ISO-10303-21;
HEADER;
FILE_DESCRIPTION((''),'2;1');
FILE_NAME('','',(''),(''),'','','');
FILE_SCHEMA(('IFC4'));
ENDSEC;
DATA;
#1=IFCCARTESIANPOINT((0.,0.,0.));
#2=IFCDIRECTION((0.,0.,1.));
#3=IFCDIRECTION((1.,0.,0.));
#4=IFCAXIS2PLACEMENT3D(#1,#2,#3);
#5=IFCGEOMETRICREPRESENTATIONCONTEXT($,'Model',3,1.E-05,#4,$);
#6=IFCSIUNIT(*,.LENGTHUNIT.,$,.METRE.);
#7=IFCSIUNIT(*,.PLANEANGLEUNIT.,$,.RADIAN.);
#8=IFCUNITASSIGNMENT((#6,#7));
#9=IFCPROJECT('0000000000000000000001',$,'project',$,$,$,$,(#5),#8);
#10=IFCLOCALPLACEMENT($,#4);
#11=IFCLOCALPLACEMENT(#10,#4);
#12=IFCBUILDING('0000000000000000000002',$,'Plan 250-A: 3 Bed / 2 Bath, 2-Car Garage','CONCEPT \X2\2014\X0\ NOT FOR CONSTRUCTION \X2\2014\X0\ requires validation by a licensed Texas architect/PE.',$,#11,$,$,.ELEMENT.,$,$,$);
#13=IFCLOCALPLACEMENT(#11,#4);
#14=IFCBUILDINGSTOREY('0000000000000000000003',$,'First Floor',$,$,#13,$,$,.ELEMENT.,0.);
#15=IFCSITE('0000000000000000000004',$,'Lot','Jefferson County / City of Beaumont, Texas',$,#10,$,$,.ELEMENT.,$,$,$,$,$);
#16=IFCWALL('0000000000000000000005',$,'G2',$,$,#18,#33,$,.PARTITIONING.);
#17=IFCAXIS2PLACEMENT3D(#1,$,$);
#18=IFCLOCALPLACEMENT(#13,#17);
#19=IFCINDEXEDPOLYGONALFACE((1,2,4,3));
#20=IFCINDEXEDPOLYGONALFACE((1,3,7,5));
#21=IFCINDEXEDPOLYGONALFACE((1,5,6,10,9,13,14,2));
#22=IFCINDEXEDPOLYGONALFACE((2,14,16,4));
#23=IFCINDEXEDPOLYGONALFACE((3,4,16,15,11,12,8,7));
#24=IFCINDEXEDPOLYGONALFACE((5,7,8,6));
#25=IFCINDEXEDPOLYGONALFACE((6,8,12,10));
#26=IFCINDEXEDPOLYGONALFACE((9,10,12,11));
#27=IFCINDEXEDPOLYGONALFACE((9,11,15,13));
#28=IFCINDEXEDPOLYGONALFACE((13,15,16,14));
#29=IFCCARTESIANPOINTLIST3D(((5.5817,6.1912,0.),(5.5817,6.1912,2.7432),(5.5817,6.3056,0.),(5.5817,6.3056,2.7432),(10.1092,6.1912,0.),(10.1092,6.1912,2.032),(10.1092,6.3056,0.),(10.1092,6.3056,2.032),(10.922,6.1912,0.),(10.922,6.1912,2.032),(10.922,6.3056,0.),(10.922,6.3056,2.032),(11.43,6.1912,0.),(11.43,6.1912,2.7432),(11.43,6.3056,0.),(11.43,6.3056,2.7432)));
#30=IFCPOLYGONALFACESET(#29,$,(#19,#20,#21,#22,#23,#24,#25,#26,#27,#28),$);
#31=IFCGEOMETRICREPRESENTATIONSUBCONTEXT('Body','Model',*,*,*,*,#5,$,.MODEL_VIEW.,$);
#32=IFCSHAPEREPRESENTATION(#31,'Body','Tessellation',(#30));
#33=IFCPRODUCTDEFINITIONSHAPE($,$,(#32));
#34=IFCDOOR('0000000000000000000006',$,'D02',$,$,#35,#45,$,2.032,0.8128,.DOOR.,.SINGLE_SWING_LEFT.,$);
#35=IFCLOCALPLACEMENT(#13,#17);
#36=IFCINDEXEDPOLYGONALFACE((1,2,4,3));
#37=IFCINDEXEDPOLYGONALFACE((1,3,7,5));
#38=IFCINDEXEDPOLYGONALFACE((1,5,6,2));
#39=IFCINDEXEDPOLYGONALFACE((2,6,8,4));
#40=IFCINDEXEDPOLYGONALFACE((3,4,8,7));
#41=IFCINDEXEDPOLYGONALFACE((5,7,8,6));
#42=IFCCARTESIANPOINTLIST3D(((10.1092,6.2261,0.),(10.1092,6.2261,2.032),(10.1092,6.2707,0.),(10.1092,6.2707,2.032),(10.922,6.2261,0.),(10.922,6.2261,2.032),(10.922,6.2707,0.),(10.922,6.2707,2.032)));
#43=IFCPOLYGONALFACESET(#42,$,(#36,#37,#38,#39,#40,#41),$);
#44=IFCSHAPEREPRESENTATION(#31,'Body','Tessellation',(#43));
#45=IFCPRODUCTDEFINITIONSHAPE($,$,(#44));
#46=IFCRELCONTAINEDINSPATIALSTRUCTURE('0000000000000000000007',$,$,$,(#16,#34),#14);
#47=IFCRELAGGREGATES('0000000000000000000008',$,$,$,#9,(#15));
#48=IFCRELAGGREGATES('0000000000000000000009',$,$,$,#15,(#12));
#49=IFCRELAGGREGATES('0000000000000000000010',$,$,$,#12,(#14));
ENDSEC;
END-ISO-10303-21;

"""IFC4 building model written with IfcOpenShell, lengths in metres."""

from ifc_helpers import new_model, si_unit, frame, frame_2d, origin_with_axes, place, context, subcontext, project, spatial, rectangle, extrude, element, fill, save


model = new_model("IFC4")

# Units and contexts
model_context = context("Model", 3, precision=1e-05, world=origin_with_axes())
body_context = subcontext(model_context, "Body", "Model", "MODEL_VIEW")
ifc_project = project(units=[si_unit("LENGTHUNIT", "METRE"), si_unit("PLANEANGLEUNIT", "RADIAN")], contexts=[model_context])

# Site, building, storey
site_placement = place(None, origin_with_axes())
site = spatial("IfcSite", under=ifc_project, at=site_placement, Name="Lot", Description="Jefferson County / City of Beaumont, Texas", CompositionType="ELEMENT")
building_placement = place(site_placement, origin_with_axes())
building = spatial("IfcBuilding", under=site, at=building_placement, Name="Plan 250-A: 3 Bed / 2 Bath, 2-Car Garage", Description="CONCEPT — NOT FOR CONSTRUCTION — requires validation by a licensed Texas architect/PE.", CompositionType="ELEMENT")
storey_placement = place(building_placement, origin_with_axes())
storey = spatial("IfcBuildingStorey", under=building, at=storey_placement, Name="First Floor", CompositionType="ELEMENT", Elevation=0.0)

# Wall, opening, door
wall_1_placement = place(storey_placement, frame((5.5817, 6.2484, 0.0), z_axis=(0.0, 0.0, 1.0), x_axis=(1.0, 0.0, 0.0)))
wall_1 = element("IfcWall", 1, at=wall_1_placement, inside=storey, Name="G2", PredefinedType="PARTITIONING", context=body_context, shape_type="SweptSolid", body=[
    extrude(rectangle(XDim=5.8483, YDim=0.1143, at=frame_2d((2.9242, 0.0), x_axis=(1.0, 0.0))), origin_with_axes(), (0.0, 0.0, 1.0), 2.7432),
])
opening_1_placement = place(wall_1_placement, frame((4.5275, 0.0, 0.0), z_axis=(0.0, 0.0, 1.0), x_axis=(1.0, 0.0, 0.0)))
opening_1 = element("IfcOpeningElement", 2, at=opening_1_placement, cuts=wall_1, PredefinedType="OPENING", context=body_context, shape_type="SweptSolid", body=[
    extrude(rectangle(XDim=0.8128, YDim=0.1448, at=frame_2d((0.4064, 0.0), x_axis=(1.0, 0.0))), origin_with_axes(), (0.0, 0.0, 1.0), 2.032),
])
door_1_placement = place(opening_1_placement, origin_with_axes())
door_1 = element("IfcDoor", 3, at=door_1_placement, inside=storey, Name="D02", OperationType="SINGLE_SWING_LEFT", OverallHeight=2.032, OverallWidth=0.8128, PredefinedType="DOOR", context=body_context, shape_type="SweptSolid", body=[
    extrude(rectangle(XDim=0.8128, YDim=0.0445, at=frame_2d((0.4064, 0.0), x_axis=(1.0, 0.0))), origin_with_axes(), (0.0, 0.0, 1.0), 2.032),
])
fill(opening_1, door_1)

save(model, "model.ifc")
